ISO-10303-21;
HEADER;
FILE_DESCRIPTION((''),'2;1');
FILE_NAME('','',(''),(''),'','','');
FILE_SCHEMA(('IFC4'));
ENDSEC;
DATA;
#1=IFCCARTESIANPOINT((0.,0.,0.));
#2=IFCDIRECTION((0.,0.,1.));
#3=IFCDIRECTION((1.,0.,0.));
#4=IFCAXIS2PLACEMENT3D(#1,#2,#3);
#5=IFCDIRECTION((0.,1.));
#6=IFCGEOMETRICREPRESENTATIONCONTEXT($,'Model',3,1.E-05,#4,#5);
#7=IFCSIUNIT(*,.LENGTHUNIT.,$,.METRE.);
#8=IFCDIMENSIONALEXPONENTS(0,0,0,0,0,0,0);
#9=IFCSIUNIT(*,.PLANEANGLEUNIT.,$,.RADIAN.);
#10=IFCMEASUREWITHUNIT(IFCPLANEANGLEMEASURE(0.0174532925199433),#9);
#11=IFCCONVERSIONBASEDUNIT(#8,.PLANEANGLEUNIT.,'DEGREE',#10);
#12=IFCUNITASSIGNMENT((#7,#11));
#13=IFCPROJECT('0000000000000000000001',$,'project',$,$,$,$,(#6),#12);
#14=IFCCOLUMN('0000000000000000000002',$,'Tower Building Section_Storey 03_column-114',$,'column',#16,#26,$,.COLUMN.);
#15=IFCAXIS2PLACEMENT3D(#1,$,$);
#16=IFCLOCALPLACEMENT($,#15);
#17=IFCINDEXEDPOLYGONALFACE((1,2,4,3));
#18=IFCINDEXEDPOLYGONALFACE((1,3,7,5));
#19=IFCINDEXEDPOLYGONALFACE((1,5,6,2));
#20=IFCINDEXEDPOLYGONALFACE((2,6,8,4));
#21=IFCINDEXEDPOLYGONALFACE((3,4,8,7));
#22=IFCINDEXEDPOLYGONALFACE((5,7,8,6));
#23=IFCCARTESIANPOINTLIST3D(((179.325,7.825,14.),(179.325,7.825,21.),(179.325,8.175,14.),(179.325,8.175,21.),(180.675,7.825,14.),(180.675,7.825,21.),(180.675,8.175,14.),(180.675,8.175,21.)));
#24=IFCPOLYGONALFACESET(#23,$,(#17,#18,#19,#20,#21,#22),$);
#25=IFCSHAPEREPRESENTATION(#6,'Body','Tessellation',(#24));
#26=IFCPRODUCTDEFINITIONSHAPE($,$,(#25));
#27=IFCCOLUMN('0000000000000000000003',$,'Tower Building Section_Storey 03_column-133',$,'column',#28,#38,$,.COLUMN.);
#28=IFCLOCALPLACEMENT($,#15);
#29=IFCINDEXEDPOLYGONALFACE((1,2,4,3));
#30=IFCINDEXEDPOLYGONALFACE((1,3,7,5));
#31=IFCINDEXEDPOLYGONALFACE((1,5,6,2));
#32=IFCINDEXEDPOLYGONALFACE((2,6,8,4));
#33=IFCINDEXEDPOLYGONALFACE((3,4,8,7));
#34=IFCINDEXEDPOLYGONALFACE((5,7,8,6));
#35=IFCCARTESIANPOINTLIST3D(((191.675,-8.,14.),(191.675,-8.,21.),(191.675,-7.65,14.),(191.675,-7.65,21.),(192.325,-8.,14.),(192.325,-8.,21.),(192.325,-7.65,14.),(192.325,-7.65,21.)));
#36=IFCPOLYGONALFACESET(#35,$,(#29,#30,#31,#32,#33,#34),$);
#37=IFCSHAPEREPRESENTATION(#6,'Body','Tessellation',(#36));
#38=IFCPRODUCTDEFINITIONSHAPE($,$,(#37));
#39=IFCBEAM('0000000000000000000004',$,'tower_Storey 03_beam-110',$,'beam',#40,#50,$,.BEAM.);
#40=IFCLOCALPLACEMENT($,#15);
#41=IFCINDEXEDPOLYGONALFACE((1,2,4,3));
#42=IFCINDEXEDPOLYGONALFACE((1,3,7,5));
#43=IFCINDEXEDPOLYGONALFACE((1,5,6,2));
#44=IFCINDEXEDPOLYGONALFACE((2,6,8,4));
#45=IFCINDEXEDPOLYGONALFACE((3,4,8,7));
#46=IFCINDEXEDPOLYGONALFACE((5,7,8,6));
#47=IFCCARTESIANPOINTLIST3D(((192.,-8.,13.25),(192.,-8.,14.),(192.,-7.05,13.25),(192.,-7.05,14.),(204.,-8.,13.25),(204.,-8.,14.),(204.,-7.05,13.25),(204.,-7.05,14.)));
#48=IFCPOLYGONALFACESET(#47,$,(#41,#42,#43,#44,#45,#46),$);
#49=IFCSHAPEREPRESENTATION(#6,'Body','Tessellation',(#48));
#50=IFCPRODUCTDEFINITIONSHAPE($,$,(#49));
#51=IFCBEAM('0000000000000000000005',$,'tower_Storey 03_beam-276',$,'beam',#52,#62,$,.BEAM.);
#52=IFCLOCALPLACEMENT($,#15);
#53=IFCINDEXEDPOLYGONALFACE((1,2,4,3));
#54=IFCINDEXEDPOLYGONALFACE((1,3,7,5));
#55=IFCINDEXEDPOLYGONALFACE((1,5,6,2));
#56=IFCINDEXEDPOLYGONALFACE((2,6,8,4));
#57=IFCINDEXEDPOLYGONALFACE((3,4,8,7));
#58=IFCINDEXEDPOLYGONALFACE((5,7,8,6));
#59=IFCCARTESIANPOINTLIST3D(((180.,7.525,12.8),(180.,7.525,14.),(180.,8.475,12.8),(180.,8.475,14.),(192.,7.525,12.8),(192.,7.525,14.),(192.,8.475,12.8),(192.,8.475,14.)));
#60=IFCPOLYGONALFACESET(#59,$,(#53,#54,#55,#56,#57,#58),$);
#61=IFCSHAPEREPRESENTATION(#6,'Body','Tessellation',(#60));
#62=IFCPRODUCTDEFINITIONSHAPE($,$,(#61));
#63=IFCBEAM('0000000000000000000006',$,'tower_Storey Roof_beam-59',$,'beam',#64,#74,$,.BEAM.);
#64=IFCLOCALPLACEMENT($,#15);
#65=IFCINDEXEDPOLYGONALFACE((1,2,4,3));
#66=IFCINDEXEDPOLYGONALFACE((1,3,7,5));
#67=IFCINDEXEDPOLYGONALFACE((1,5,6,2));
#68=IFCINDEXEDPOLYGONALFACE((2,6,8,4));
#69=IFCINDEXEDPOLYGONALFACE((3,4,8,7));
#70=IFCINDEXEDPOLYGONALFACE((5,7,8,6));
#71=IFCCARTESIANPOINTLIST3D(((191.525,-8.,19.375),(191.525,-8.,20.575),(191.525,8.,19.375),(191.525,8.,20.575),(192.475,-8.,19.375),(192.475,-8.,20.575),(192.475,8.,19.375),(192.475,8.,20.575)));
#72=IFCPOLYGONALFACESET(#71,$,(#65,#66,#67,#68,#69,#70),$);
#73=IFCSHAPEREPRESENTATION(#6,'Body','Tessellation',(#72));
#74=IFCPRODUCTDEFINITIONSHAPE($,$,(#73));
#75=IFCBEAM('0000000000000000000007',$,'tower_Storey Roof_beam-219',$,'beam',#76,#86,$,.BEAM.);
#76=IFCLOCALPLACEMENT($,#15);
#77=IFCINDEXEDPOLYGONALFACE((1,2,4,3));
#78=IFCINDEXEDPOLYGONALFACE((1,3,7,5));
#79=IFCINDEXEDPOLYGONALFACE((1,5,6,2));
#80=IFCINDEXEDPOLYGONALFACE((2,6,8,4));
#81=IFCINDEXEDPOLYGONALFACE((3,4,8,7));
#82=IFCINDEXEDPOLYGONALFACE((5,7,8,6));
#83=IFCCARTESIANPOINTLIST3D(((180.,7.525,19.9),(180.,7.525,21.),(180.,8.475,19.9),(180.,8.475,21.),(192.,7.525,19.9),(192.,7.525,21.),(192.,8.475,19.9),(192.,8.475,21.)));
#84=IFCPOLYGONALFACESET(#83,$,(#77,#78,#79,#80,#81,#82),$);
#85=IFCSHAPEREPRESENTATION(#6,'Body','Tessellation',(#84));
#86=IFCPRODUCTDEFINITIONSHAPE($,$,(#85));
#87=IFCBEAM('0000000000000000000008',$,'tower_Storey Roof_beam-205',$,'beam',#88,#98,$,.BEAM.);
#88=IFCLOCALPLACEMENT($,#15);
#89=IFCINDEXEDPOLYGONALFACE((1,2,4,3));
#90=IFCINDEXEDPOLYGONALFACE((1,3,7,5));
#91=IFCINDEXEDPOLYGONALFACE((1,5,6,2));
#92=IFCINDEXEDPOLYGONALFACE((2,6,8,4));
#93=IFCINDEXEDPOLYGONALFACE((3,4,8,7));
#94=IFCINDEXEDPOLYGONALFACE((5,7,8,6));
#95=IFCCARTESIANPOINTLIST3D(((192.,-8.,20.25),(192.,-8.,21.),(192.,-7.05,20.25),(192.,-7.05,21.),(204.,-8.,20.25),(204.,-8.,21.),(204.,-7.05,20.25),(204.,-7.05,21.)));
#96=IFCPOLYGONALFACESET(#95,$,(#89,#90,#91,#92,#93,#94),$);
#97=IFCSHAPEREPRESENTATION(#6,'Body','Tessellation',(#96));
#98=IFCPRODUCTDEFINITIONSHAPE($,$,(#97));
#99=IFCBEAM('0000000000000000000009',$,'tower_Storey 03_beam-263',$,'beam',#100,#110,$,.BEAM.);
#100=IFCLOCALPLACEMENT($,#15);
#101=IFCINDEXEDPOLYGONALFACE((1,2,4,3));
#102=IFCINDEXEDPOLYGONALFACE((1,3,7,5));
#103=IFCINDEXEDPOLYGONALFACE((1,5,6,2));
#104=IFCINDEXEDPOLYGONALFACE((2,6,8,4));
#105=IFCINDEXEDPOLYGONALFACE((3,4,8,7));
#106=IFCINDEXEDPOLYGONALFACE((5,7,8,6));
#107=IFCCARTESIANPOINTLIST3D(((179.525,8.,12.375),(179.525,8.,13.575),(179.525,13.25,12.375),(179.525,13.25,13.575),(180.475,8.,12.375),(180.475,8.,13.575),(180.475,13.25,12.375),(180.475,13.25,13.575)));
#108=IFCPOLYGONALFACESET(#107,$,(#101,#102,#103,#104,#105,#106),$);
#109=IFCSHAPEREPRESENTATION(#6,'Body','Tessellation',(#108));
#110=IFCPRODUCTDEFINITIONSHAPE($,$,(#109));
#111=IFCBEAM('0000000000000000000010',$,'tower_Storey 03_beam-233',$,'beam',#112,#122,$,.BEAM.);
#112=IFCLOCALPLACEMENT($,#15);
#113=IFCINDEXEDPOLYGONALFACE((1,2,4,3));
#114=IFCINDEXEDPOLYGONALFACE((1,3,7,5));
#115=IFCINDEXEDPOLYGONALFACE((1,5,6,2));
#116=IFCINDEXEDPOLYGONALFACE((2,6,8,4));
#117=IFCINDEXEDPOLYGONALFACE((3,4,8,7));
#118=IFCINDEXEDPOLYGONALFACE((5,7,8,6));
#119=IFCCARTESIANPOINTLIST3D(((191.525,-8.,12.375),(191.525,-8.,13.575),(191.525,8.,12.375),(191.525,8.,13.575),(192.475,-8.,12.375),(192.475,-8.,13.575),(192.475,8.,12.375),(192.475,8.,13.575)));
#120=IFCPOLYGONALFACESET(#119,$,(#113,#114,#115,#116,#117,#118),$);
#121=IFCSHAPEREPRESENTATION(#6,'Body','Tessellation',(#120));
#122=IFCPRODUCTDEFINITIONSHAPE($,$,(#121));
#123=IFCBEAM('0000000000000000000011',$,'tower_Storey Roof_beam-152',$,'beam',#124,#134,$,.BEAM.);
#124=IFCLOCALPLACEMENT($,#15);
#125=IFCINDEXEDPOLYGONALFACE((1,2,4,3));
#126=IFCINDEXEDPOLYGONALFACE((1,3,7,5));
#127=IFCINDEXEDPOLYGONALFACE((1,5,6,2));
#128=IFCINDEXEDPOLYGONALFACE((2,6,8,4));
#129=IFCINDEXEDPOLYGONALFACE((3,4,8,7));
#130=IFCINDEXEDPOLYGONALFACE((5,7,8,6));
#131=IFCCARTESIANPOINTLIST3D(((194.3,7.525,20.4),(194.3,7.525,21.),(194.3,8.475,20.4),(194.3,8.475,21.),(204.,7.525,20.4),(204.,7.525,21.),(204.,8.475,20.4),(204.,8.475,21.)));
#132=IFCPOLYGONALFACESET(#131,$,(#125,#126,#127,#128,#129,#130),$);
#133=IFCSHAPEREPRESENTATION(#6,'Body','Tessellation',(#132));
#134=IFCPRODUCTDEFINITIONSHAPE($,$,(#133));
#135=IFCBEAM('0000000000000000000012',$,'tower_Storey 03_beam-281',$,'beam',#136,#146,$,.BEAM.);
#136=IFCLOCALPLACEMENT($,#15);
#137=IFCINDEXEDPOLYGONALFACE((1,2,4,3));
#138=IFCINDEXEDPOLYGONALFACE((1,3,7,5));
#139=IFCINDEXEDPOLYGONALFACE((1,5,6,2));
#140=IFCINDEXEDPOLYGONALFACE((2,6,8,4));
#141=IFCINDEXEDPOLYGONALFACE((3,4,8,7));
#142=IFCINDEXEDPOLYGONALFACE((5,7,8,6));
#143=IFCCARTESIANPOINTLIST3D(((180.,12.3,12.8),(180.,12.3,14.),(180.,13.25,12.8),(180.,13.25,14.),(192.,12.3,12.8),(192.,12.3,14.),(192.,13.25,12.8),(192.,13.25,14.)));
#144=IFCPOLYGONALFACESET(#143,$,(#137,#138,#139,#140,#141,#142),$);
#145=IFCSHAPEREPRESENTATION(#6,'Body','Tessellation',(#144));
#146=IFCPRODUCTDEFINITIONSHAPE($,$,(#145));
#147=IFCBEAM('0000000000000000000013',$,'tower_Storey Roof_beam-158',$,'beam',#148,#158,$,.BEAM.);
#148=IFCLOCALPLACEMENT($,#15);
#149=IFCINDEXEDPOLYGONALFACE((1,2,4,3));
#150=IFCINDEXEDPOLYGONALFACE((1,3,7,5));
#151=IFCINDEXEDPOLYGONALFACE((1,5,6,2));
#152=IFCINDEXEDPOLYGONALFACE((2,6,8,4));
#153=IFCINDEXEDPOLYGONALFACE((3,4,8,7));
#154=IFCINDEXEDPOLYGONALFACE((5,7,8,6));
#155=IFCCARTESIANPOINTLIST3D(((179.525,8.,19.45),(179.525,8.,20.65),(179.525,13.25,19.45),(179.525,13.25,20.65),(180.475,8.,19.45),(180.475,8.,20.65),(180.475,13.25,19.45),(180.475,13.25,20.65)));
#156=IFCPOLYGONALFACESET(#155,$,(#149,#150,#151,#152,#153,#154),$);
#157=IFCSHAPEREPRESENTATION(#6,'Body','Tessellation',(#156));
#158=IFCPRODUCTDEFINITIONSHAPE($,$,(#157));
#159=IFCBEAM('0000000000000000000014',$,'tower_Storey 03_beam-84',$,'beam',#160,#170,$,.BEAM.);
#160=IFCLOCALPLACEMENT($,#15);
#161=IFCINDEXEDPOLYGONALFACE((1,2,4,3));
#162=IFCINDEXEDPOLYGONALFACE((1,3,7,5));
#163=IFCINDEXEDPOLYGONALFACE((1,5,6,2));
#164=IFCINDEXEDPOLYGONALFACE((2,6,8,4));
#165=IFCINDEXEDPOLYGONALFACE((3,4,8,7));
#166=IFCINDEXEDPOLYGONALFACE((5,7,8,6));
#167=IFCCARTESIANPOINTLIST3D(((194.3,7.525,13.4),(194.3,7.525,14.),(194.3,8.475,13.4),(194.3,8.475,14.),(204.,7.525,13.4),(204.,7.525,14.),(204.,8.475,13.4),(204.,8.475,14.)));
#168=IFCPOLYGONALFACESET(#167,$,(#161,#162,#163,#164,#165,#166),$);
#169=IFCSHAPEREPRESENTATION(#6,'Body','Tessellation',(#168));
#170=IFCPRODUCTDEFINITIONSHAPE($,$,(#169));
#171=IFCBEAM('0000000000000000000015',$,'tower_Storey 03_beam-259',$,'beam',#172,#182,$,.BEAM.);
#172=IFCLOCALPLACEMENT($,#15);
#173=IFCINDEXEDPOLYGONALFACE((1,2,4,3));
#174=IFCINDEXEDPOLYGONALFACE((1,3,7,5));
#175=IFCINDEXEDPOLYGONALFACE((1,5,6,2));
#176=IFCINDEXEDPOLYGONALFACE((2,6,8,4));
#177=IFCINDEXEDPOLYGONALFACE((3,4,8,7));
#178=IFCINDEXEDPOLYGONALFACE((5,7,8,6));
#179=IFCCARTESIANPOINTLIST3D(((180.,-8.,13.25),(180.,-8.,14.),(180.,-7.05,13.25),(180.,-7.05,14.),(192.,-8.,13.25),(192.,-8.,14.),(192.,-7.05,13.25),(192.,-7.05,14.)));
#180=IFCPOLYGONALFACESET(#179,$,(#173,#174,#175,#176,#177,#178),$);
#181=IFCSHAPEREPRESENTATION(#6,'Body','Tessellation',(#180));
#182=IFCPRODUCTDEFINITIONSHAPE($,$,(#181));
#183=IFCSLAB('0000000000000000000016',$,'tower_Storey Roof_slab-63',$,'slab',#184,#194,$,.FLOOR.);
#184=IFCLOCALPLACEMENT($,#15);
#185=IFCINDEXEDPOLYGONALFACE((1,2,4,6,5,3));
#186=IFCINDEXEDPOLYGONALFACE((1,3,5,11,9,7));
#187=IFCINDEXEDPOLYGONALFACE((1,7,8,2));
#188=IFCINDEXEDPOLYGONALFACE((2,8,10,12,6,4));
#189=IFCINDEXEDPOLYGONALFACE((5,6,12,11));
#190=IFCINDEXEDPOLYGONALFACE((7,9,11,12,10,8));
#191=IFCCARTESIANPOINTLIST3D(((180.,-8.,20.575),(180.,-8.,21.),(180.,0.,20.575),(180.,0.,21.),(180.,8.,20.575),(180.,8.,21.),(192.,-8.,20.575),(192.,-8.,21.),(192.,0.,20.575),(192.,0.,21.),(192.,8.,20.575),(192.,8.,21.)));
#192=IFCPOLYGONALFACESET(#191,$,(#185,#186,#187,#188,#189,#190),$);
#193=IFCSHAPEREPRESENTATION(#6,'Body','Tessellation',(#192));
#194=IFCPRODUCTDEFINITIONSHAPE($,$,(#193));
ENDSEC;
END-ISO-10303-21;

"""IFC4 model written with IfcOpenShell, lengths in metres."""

from ifc_helpers import new_model, entity, si_unit, converted_unit, direction, frame, origin_with_axes, place, context, project, polyline, outline, extrude, element, save


model = new_model("IFC4")

# Units and contexts
model_context = context("Model", 3, precision=1e-05, world=origin_with_axes(), true_north=direction((0.0, 1.0)))
ifc_project = project(units=[si_unit("LENGTHUNIT", "METRE"), converted_unit("PLANEANGLEUNIT", "DEGREE", entity("IfcPlaneAngleMeasure", 0.0174532925199433), si_unit("PLANEANGLEUNIT", "RADIAN"), dimensions=[0, 0, 0, 0, 0, 0, 0])], contexts=[model_context])

# Columns
placement_1 = place(None, origin_with_axes())
placement_2 = place(placement_1, frame((0.0, 0.0, 14.0), z_axis=(0.0, 0.0, 1.0), x_axis=(1.0, 0.0, 0.0)))
column_1_placement = place(placement_2, frame((180.0, 8.0, 0.0), z_axis=(0.0, 0.0, 1.0), x_axis=(1.0, 0.0, 0.0)))
element("IfcColumn", 1, at=column_1_placement, Name="Tower Building Section_Storey 03_column-114", ObjectType="column", PredefinedType="COLUMN", context=model_context, body=[
    extrude(outline(polyline([(-0.675, -0.175, 0.0), (0.675, -0.175, 0.0), (0.675, 0.175, 0.0), (-0.675, 0.175, 0.0), (-0.675, -0.175, 0.0)])), origin_with_axes(), (0.0, 0.0, 1.0), 7.0),
])
column_2_placement = place(placement_2, frame((192.0, -7.825, 0.0), z_axis=(0.0, 0.0, 1.0), x_axis=(1.0, 0.0, 0.0)))
element("IfcColumn", 2, at=column_2_placement, Name="Tower Building Section_Storey 03_column-133", ObjectType="column", PredefinedType="COLUMN", context=model_context, body=[
    extrude(outline(polyline([(-0.325, -0.175, 0.0), (0.325, -0.175, 0.0), (0.325, 0.175, 0.0), (-0.325, 0.175, 0.0), (-0.325, -0.175, 0.0)])), origin_with_axes(), (0.0, 0.0, 1.0), 7.0),
])

# Beams
beam_1_placement = place(placement_2, frame((192.0, -7.525, -0.375), z_axis=(1.0, 0.0, 0.0), x_axis=(0.0, 1.0, 0.0)))
element("IfcBeam", 3, at=beam_1_placement, Name="tower_Storey 03_beam-110", ObjectType="beam", PredefinedType="BEAM", context=model_context, body=[
    extrude(outline(polyline([(0.475, 0.375, 0.0), (-0.475, 0.375, 0.0), (-0.475, -0.375, 0.0), (0.475, -0.375, 0.0), (0.475, 0.375, 0.0)])), origin_with_axes(), (0.0, 0.0, 1.0), 12.0),
])
beam_2_placement = place(placement_2, frame((180.0, 8.0, -0.6), z_axis=(1.0, 0.0, 0.0), x_axis=(0.0, 1.0, 0.0)))
element("IfcBeam", 4, at=beam_2_placement, Name="tower_Storey 03_beam-276", ObjectType="beam", PredefinedType="BEAM", context=model_context, body=[
    extrude(outline(polyline([(0.475, 0.6, 0.0), (-0.475, 0.6, 0.0), (-0.475, -0.6, 0.0), (0.475, -0.6, 0.0), (0.475, 0.6, 0.0)])), origin_with_axes(), (0.0, 0.0, 1.0), 12.0),
])
placement_3 = place(placement_1, frame((0.0, 0.0, 21.0), z_axis=(0.0, 0.0, 1.0), x_axis=(1.0, 0.0, 0.0)))
beam_3_placement = place(placement_3, frame((192.0, -8.0, -1.025), z_axis=(0.0, 1.0, 0.0), x_axis=(-1.0, 0.0, 0.0)))
element("IfcBeam", 5, at=beam_3_placement, Name="tower_Storey Roof_beam-59", ObjectType="beam", PredefinedType="BEAM", context=model_context, body=[
    extrude(outline(polyline([(0.475, 0.6, 0.0), (-0.475, 0.6, 0.0), (-0.475, -0.6, 0.0), (0.475, -0.6, 0.0), (0.475, 0.6, 0.0)])), origin_with_axes(), (0.0, 0.0, 1.0), 16.0),
])
beam_4_placement = place(placement_3, frame((180.0, 8.0, -0.55), z_axis=(1.0, 0.0, 0.0), x_axis=(0.0, 1.0, 0.0)))
element("IfcBeam", 6, at=beam_4_placement, Name="tower_Storey Roof_beam-219", ObjectType="beam", PredefinedType="BEAM", context=model_context, body=[
    extrude(outline(polyline([(0.475, 0.55, 0.0), (-0.475, 0.55, 0.0), (-0.475, -0.55, 0.0), (0.475, -0.55, 0.0), (0.475, 0.55, 0.0)])), origin_with_axes(), (0.0, 0.0, 1.0), 12.0),
])
beam_5_placement = place(placement_3, frame((192.0, -7.525, -0.375), z_axis=(1.0, 0.0, 0.0), x_axis=(0.0, 1.0, 0.0)))
element("IfcBeam", 7, at=beam_5_placement, Name="tower_Storey Roof_beam-205", ObjectType="beam", PredefinedType="BEAM", context=model_context, body=[
    extrude(outline(polyline([(0.475, 0.375, 0.0), (-0.475, 0.375, 0.0), (-0.475, -0.375, 0.0), (0.475, -0.375, 0.0), (0.475, 0.375, 0.0)])), origin_with_axes(), (0.0, 0.0, 1.0), 12.0),
])
beam_6_placement = place(placement_2, frame((180.0, 8.0, -1.025), z_axis=(0.0, 1.0, 0.0), x_axis=(-1.0, 0.0, 0.0)))
element("IfcBeam", 8, at=beam_6_placement, Name="tower_Storey 03_beam-263", ObjectType="beam", PredefinedType="BEAM", context=model_context, body=[
    extrude(outline(polyline([(0.475, 0.6, 0.0), (-0.475, 0.6, 0.0), (-0.475, -0.6, 0.0), (0.475, -0.6, 0.0), (0.475, 0.6, 0.0)])), origin_with_axes(), (0.0, 0.0, 1.0), 5.25),
])
beam_7_placement = place(placement_2, frame((192.0, -8.0, -1.025), z_axis=(0.0, 1.0, 0.0), x_axis=(-1.0, 0.0, 0.0)))
element("IfcBeam", 9, at=beam_7_placement, Name="tower_Storey 03_beam-233", ObjectType="beam", PredefinedType="BEAM", context=model_context, body=[
    extrude(outline(polyline([(0.475, 0.6, 0.0), (-0.475, 0.6, 0.0), (-0.475, -0.6, 0.0), (0.475, -0.6, 0.0), (0.475, 0.6, 0.0)])), origin_with_axes(), (0.0, 0.0, 1.0), 16.0),
])
beam_8_placement = place(placement_3, frame((194.3, 8.0, -0.3), z_axis=(1.0, 0.0, 0.0), x_axis=(0.0, 1.0, 0.0)))
element("IfcBeam", 10, at=beam_8_placement, Name="tower_Storey Roof_beam-152", ObjectType="beam", PredefinedType="BEAM", context=model_context, body=[
    extrude(outline(polyline([(0.475, 0.3, 0.0), (-0.475, 0.3, 0.0), (-0.475, -0.3, 0.0), (0.475, -0.3, 0.0), (0.475, 0.3, 0.0)])), origin_with_axes(), (0.0, 0.0, 1.0), 9.7),
])
beam_9_placement = place(placement_2, frame((180.0, 12.775, -0.6), z_axis=(1.0, 0.0, 0.0), x_axis=(0.0, 1.0, 0.0)))
element("IfcBeam", 11, at=beam_9_placement, Name="tower_Storey 03_beam-281", ObjectType="beam", PredefinedType="BEAM", context=model_context, body=[
    extrude(outline(polyline([(0.475, 0.6, 0.0), (-0.475, 0.6, 0.0), (-0.475, -0.6, 0.0), (0.475, -0.6, 0.0), (0.475, 0.6, 0.0)])), origin_with_axes(), (0.0, 0.0, 1.0), 12.0),
])
beam_10_placement = place(placement_3, frame((180.0, 8.0, -0.95), z_axis=(0.0, 1.0, 0.0), x_axis=(-1.0, 0.0, 0.0)))
element("IfcBeam", 12, at=beam_10_placement, Name="tower_Storey Roof_beam-158", ObjectType="beam", PredefinedType="BEAM", context=model_context, body=[
    extrude(outline(polyline([(0.475, 0.6, 0.0), (-0.475, 0.6, 0.0), (-0.475, -0.6, 0.0), (0.475, -0.6, 0.0), (0.475, 0.6, 0.0)])), origin_with_axes(), (0.0, 0.0, 1.0), 5.25),
])
beam_11_placement = place(placement_2, frame((194.3, 8.0, -0.3), z_axis=(1.0, 0.0, 0.0), x_axis=(0.0, 1.0, 0.0)))
element("IfcBeam", 13, at=beam_11_placement, Name="tower_Storey 03_beam-84", ObjectType="beam", PredefinedType="BEAM", context=model_context, body=[
    extrude(outline(polyline([(0.475, 0.3, 0.0), (-0.475, 0.3, 0.0), (-0.475, -0.3, 0.0), (0.475, -0.3, 0.0), (0.475, 0.3, 0.0)])), origin_with_axes(), (0.0, 0.0, 1.0), 9.7),
])
beam_12_placement = place(placement_2, frame((180.0, -7.525, -0.375), z_axis=(1.0, 0.0, 0.0), x_axis=(0.0, 1.0, 0.0)))
element("IfcBeam", 14, at=beam_12_placement, Name="tower_Storey 03_beam-259", ObjectType="beam", PredefinedType="BEAM", context=model_context, body=[
    extrude(outline(polyline([(0.475, 0.375, 0.0), (-0.475, 0.375, 0.0), (-0.475, -0.375, 0.0), (0.475, -0.375, 0.0), (0.475, 0.375, 0.0)])), origin_with_axes(), (0.0, 0.0, 1.0), 12.0),
])

# Slab
slab_1_placement = place(placement_3, frame((186.0, 0.0, -0.425), z_axis=(0.0, 0.0, 1.0), x_axis=(1.0, 0.0, 0.0)))
element("IfcSlab", 15, at=slab_1_placement, Name="tower_Storey Roof_slab-63", ObjectType="slab", PredefinedType="FLOOR", context=model_context, body=[
    extrude(outline(polyline([(-6.0, -8.0, 0.0), (6.0, -8.0, 0.0), (6.0, 0.0, 0.0), (6.0, 8.0, 0.0), (-6.0, 8.0, 0.0), (-6.0, 0.0, 0.0), (-6.0, -8.0, 0.0)])), origin_with_axes(), (0.0, 0.0, 1.0), 0.425),
])

save(model, "model.ifc")
